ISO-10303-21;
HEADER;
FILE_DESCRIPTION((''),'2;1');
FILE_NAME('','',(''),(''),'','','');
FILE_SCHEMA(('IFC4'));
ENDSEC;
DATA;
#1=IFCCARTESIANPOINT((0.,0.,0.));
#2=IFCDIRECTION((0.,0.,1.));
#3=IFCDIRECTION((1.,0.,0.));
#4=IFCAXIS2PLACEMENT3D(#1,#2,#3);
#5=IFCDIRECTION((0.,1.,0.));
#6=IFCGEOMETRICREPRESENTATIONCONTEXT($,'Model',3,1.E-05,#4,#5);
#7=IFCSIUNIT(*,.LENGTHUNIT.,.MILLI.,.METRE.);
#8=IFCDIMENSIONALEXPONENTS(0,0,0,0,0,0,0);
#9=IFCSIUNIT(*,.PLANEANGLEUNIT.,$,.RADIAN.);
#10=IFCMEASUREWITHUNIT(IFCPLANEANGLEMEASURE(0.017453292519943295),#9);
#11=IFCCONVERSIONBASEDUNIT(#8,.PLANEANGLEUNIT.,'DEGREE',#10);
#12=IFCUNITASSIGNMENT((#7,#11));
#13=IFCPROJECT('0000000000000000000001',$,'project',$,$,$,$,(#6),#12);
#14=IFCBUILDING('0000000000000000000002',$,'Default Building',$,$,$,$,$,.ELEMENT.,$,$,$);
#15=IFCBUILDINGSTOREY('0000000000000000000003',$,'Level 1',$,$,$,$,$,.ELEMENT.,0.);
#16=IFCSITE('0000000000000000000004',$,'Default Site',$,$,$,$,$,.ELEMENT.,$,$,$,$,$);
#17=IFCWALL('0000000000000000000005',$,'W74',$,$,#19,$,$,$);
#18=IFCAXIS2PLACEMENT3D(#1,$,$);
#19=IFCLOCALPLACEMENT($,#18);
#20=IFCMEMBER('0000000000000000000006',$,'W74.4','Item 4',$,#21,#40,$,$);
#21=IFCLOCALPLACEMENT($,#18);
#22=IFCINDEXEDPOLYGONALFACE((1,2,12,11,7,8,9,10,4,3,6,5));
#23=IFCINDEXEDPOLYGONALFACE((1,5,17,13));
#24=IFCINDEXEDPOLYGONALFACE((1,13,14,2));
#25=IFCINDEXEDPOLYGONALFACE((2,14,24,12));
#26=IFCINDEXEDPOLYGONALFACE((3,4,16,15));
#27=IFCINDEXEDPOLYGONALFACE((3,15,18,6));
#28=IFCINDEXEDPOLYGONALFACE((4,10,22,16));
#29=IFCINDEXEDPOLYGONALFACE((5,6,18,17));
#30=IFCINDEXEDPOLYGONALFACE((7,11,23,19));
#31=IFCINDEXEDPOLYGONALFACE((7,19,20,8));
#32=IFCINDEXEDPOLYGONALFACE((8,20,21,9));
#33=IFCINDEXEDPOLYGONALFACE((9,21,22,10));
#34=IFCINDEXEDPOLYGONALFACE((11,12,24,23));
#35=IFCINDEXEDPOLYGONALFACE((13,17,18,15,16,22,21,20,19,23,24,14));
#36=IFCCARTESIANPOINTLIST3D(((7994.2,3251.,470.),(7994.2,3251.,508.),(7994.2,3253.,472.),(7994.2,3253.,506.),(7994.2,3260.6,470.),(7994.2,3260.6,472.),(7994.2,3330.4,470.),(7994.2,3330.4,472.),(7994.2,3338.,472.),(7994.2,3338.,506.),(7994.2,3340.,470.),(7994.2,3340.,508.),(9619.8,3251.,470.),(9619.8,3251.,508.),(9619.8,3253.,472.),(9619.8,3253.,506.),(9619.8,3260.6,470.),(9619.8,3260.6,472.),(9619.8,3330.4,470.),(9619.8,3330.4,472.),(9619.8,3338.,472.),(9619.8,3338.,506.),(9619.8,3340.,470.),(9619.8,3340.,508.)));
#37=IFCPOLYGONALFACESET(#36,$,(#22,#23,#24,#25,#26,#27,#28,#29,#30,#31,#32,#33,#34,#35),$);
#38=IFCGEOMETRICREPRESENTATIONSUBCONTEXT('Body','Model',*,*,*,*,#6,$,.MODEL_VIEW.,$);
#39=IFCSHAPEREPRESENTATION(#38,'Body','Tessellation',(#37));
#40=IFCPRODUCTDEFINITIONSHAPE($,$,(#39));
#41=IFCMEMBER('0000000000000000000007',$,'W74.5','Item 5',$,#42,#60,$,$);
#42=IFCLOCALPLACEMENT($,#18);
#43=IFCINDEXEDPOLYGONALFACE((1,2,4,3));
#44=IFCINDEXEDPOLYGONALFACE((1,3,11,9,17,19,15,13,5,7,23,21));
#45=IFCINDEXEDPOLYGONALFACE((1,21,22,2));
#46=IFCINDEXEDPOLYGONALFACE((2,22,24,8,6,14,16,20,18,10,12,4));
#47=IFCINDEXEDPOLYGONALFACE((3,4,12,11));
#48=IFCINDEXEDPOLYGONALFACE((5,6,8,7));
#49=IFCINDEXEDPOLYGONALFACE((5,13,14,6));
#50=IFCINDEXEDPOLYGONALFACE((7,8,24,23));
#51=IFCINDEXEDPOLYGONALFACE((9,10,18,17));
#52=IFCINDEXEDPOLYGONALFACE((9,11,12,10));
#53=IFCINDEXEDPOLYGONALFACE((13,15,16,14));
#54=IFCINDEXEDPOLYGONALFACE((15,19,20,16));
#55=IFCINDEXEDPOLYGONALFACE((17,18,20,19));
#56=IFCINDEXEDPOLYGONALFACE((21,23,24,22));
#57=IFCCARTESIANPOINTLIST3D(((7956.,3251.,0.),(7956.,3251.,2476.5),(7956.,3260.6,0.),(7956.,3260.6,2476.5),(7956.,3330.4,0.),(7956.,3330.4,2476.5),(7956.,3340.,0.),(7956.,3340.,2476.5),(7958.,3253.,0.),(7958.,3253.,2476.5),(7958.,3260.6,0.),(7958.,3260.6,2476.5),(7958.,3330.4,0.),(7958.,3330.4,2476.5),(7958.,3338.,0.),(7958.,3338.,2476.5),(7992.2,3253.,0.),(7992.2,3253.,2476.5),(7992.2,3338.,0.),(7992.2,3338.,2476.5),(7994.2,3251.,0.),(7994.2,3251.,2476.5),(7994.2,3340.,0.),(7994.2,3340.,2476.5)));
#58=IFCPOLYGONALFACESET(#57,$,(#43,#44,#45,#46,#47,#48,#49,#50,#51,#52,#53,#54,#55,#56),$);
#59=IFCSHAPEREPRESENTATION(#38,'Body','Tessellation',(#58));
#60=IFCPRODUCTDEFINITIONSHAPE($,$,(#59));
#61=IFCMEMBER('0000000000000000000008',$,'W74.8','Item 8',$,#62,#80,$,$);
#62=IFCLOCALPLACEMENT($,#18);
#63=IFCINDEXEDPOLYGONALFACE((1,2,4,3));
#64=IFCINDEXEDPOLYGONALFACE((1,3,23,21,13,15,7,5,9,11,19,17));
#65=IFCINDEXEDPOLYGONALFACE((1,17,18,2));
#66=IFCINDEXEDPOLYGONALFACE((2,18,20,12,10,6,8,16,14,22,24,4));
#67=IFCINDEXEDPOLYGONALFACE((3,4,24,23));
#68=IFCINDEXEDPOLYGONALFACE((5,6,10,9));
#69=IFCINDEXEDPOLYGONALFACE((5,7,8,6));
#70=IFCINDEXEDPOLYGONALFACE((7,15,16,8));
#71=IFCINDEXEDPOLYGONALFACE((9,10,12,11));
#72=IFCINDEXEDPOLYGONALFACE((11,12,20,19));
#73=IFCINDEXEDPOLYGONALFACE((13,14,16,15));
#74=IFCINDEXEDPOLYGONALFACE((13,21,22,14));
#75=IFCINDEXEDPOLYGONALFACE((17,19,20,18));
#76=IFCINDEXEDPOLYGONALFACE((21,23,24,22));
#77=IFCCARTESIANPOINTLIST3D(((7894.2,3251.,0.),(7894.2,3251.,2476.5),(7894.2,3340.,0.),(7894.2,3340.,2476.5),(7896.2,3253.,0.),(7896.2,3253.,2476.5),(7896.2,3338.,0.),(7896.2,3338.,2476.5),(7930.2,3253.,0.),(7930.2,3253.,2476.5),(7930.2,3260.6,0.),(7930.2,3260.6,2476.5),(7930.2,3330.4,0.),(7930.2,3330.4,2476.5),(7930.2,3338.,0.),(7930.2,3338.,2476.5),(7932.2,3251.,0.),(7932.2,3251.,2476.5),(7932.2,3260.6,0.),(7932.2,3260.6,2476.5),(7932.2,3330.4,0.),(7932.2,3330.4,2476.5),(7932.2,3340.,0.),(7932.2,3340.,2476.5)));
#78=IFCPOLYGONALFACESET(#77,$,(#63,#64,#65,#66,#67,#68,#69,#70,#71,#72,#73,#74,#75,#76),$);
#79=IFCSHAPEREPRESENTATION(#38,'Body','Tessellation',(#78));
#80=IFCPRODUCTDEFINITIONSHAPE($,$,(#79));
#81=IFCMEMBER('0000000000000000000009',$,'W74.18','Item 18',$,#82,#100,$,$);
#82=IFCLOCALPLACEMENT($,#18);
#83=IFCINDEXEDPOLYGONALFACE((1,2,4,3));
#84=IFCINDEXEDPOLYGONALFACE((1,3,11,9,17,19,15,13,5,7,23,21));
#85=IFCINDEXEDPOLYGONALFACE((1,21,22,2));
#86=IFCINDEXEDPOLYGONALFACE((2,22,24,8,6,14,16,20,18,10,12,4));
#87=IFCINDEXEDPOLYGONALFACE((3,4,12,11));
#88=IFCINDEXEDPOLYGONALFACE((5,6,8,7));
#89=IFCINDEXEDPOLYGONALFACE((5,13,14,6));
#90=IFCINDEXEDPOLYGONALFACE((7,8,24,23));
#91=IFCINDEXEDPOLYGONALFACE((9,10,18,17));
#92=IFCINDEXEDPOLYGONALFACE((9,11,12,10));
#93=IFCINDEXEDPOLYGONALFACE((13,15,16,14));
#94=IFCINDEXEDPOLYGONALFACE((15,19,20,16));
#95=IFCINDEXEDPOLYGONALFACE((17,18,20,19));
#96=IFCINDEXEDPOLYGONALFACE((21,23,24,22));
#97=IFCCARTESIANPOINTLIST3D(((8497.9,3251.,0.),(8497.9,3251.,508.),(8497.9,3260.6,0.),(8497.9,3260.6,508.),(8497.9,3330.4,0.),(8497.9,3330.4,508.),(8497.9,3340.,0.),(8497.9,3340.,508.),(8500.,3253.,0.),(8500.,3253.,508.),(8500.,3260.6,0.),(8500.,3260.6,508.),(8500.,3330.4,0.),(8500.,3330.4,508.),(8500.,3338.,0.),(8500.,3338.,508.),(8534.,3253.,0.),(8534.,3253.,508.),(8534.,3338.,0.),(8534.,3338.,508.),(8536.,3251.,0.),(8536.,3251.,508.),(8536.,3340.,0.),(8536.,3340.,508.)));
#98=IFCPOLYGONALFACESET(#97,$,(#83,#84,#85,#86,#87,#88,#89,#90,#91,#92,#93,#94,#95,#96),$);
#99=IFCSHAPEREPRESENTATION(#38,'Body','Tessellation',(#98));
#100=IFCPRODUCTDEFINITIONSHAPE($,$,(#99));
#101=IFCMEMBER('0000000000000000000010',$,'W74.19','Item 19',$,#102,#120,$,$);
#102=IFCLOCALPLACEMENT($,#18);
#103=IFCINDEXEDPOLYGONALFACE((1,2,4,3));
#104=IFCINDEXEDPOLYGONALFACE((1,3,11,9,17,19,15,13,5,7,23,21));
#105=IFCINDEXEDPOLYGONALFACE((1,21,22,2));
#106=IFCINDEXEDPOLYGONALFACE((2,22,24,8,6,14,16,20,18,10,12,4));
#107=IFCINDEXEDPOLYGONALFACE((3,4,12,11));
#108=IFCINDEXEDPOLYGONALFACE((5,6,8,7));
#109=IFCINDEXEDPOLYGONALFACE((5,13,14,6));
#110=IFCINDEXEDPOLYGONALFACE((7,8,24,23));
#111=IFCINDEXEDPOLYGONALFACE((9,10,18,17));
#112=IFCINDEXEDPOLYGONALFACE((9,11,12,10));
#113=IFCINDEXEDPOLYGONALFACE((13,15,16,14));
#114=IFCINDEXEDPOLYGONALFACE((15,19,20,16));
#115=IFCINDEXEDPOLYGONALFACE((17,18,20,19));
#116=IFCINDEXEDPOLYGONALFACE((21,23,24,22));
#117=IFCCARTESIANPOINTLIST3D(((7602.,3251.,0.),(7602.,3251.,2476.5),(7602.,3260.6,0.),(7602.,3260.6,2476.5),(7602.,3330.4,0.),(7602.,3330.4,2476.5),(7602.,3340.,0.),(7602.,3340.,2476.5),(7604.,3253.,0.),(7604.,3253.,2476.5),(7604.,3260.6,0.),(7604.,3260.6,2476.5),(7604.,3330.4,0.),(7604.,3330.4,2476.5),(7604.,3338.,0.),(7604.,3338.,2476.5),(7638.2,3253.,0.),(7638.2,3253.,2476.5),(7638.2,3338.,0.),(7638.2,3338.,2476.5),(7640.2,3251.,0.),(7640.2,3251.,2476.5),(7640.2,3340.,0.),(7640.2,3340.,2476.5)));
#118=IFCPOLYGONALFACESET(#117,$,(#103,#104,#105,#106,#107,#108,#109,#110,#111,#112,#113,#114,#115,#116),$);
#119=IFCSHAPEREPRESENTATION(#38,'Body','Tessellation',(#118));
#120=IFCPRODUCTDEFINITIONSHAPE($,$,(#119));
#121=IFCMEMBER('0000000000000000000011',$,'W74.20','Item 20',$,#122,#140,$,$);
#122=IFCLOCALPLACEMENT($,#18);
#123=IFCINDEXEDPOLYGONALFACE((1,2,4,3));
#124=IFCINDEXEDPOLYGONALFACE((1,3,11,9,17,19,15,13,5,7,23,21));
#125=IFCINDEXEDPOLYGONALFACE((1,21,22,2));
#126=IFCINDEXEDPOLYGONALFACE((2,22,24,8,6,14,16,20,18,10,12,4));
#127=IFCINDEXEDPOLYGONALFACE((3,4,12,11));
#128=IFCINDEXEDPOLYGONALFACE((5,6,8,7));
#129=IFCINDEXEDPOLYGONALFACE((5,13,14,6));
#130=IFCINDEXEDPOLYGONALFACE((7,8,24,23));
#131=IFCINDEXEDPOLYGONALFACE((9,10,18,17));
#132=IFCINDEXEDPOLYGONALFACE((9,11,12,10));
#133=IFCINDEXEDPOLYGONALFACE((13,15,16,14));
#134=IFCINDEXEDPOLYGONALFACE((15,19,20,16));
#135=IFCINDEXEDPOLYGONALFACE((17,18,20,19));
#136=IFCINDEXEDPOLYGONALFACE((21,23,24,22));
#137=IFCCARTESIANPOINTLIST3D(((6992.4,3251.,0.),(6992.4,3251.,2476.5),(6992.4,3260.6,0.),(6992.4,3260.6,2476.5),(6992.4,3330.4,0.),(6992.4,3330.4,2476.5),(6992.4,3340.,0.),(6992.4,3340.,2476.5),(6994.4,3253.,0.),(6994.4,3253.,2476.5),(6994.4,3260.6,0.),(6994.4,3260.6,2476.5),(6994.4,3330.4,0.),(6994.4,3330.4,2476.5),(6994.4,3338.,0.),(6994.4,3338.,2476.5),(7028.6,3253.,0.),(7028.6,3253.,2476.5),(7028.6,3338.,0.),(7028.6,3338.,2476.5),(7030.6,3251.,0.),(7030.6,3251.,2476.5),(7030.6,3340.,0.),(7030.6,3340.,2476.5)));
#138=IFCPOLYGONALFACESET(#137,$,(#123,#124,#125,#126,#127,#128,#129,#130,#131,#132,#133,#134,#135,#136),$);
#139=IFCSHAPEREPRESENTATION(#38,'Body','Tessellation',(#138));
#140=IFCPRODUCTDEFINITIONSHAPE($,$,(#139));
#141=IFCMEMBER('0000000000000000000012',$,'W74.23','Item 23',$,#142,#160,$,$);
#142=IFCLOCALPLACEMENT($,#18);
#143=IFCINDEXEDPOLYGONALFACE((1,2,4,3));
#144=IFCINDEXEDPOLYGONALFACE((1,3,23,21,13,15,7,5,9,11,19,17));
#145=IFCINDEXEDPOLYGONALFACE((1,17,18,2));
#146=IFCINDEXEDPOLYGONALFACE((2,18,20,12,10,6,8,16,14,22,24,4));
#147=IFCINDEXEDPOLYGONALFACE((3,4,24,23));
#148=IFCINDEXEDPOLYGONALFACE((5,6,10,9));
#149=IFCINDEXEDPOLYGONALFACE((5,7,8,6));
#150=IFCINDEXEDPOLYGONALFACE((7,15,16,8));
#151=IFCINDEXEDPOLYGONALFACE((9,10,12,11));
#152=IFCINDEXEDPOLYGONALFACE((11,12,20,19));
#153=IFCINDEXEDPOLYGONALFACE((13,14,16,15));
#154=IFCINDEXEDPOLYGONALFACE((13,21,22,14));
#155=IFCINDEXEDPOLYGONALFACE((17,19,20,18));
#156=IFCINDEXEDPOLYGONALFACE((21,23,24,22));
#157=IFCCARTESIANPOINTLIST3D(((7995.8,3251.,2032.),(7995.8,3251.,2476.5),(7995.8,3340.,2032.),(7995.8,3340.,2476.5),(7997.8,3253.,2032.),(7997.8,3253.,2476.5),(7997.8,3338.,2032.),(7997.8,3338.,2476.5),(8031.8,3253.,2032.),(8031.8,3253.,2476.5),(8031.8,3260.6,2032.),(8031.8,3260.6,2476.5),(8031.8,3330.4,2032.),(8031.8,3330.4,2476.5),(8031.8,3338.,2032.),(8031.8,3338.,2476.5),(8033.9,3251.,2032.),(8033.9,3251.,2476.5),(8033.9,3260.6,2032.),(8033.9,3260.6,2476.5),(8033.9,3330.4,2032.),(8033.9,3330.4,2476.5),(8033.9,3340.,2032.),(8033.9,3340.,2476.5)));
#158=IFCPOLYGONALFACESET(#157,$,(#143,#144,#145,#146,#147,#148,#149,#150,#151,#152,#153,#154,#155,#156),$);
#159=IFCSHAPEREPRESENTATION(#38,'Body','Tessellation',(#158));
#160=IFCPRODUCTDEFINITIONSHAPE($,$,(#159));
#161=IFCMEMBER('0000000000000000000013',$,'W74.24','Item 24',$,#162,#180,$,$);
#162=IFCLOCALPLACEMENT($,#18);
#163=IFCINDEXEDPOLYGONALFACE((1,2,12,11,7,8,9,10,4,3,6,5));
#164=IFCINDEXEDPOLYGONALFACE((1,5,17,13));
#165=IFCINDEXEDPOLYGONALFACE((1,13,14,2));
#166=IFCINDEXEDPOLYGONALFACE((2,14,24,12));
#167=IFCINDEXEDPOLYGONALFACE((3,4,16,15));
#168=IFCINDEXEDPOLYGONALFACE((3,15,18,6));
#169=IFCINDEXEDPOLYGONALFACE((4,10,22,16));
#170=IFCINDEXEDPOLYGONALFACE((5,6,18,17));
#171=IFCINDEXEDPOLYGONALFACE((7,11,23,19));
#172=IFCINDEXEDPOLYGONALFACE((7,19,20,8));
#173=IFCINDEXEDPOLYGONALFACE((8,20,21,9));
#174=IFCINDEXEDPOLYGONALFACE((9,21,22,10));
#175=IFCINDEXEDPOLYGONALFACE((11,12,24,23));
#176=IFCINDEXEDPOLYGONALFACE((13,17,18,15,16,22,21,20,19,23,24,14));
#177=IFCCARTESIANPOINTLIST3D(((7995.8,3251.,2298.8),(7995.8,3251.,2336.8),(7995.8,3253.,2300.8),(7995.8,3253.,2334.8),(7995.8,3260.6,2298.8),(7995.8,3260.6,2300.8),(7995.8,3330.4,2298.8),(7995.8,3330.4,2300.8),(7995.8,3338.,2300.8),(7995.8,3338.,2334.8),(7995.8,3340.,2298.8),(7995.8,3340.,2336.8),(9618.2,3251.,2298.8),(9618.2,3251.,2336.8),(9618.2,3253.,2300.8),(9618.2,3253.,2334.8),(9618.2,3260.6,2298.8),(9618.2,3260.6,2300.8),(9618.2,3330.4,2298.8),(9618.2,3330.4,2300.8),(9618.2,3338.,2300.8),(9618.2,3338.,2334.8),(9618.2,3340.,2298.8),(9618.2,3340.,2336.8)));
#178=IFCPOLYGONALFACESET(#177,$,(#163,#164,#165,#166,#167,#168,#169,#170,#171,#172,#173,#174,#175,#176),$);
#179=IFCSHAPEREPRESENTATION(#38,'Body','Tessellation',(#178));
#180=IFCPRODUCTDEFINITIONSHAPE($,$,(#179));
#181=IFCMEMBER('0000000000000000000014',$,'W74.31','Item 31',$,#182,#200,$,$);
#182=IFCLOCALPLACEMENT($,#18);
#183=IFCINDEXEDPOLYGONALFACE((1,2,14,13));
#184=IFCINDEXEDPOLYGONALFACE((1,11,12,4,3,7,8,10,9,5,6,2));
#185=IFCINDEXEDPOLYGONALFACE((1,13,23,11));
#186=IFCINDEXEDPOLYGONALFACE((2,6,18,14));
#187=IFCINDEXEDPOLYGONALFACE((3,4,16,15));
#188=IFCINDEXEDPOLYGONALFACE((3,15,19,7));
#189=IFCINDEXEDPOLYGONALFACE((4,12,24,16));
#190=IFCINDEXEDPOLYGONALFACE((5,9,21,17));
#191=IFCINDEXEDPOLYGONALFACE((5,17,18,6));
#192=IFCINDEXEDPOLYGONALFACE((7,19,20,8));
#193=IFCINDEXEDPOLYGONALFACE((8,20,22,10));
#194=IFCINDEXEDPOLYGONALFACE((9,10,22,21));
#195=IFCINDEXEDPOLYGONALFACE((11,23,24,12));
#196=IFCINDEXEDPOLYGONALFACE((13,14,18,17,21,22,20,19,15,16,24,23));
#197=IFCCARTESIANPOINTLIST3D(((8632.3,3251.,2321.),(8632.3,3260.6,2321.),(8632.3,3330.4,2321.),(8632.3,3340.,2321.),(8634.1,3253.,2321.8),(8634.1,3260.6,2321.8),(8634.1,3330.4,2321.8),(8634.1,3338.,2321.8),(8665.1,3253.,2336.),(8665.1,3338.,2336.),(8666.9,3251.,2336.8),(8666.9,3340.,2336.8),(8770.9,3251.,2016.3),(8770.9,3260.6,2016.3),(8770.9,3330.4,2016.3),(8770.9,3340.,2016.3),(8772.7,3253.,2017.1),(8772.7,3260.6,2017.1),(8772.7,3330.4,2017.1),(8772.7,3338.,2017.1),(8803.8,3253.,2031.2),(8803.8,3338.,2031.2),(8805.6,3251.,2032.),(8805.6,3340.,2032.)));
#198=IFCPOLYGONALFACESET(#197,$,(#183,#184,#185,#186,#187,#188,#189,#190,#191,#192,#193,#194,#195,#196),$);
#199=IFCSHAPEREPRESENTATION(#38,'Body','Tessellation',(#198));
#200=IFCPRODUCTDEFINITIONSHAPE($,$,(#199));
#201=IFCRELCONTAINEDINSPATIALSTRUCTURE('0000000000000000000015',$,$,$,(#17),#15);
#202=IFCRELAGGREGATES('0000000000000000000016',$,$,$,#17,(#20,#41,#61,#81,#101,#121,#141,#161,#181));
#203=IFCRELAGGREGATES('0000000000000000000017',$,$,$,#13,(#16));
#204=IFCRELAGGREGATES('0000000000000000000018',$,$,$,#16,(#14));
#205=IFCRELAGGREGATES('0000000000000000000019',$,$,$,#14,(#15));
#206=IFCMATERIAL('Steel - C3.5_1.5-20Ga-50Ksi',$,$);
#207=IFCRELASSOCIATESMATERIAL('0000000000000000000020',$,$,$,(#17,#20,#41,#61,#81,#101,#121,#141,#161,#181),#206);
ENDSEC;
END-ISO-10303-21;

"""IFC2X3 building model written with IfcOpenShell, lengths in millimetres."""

from ifc_helpers import new_model, entity, si_unit, converted_unit, direction, frame, origin, origin_with_axes, origin_2d_with_axis, place, context, subcontext, project, spatial, c_section, extrude, material, element, aggregate, save


model = new_model("IFC2X3")

# Units and contexts
model_context = context("Model", 3, precision=1e-05, world=origin_with_axes(), true_north=direction((0.0, 1.0, 0.0)))
body_context = subcontext(model_context, "Body", "Model", "MODEL_VIEW")
ifc_project = project(units=[si_unit("LENGTHUNIT", "METRE", prefix="MILLI"), converted_unit("PLANEANGLEUNIT", "DEGREE", entity("IfcPlaneAngleMeasure", 0.017453292519943295), si_unit("PLANEANGLEUNIT", "RADIAN"), dimensions=[0, 0, 0, 0, 0, 0, 0])], contexts=[model_context])

# Site, building, storey
site = spatial("IfcSite", under=ifc_project, Name="Default Site", CompositionType="ELEMENT")
building = spatial("IfcBuilding", under=site, Name="Default Building", CompositionType="ELEMENT")
storey = spatial("IfcBuildingStorey", under=building, Name="Level 1", CompositionType="ELEMENT", Elevation=0.0)

# Wall, members
ifc_material_1 = material(Name="Steel - C3.5_1.5-20Ga-50Ksi")
wall = element("IfcWall", 1, inside=storey, material=ifc_material_1, Name="W74")
member_1_placement = place(None, frame((7994.2, 3295.5, 489.0), z_axis=(1.0, 0.0, 0.0), x_axis=(0.0, 0.0, -1.0)))
member_1 = element("IfcMember", 2, at=member_1_placement, material=ifc_material_1, Name="W74.4", Description="Item 4", context=body_context, shape_type="SweptSolid", body=[
    extrude(c_section(Depth=88.9, Width=38.1, WallThickness=2.0, Girth=9.5, at=origin_2d_with_axis()), origin(), (0.0, 0.0, 1.0), 1625.6),
])
member_2_placement = place(None, frame((7975.1, 3295.5, 2476.5), z_axis=(0.0, 0.0, -1.0), x_axis=(-1.0, 0.0, 0.0)))
member_2 = element("IfcMember", 3, at=member_2_placement, material=ifc_material_1, Name="W74.5", Description="Item 5", context=body_context, shape_type="SweptSolid", body=[
    extrude(c_section(Depth=88.9, Width=38.1, WallThickness=2.0, Girth=9.5, at=origin_2d_with_axis()), origin(), (0.0, 0.0, 1.0), 2476.5),
])
member_3_placement = place(None, frame((7913.2, 3295.5, 0.0), z_axis=(0.0, 0.0, 1.0), x_axis=(1.0, 0.0, 0.0)))
member_3 = element("IfcMember", 4, at=member_3_placement, material=ifc_material_1, Name="W74.8", Description="Item 8", context=body_context, shape_type="SweptSolid", body=[
    extrude(c_section(Depth=88.9, Width=38.1, WallThickness=2.0, Girth=9.5, at=origin_2d_with_axis()), origin(), (0.0, 0.0, 1.0), 2476.5),
])
member_4_placement = place(None, frame((8517.0, 3295.5, 508.0), z_axis=(0.0, 0.0, -1.0), x_axis=(-1.0, 0.0, 0.0)))
member_4 = element("IfcMember", 5, at=member_4_placement, material=ifc_material_1, Name="W74.18", Description="Item 18", context=body_context, shape_type="SweptSolid", body=[
    extrude(c_section(Depth=88.9, Width=38.1, WallThickness=2.0, Girth=9.5, at=origin_2d_with_axis()), origin(), (0.0, 0.0, 1.0), 508.0),
])
member_5_placement = place(None, frame((7621.1, 3295.5, 2476.5), z_axis=(0.0, 0.0, -1.0), x_axis=(-1.0, 0.0, 0.0)))
member_5 = element("IfcMember", 6, at=member_5_placement, material=ifc_material_1, Name="W74.19", Description="Item 19", context=body_context, shape_type="SweptSolid", body=[
    extrude(c_section(Depth=88.9, Width=38.1, WallThickness=2.0, Girth=9.5, at=origin_2d_with_axis()), origin(), (0.0, 0.0, 1.0), 2476.5),
])
member_6_placement = place(None, frame((7011.5, 3295.5, 2476.5), z_axis=(0.0, 0.0, -1.0), x_axis=(-1.0, 0.0, 0.0)))
member_6 = element("IfcMember", 7, at=member_6_placement, material=ifc_material_1, Name="W74.20", Description="Item 20", context=body_context, shape_type="SweptSolid", body=[
    extrude(c_section(Depth=88.9, Width=38.1, WallThickness=2.0, Girth=9.5, at=origin_2d_with_axis()), origin(), (0.0, 0.0, 1.0), 2476.5),
])
member_7_placement = place(None, frame((8014.8, 3295.5, 2032.0), z_axis=(0.0, 0.0, 1.0), x_axis=(1.0, 0.0, 0.0)))
member_7 = element("IfcMember", 8, at=member_7_placement, material=ifc_material_1, Name="W74.23", Description="Item 23", context=body_context, shape_type="SweptSolid", body=[
    extrude(c_section(Depth=88.9, Width=38.1, WallThickness=2.0, Girth=9.5, at=origin_2d_with_axis()), origin(), (0.0, 0.0, 1.0), 444.5),
])
member_8_placement = place(None, frame((7995.8, 3295.5, 2317.8), z_axis=(1.0, 0.0, 0.0), x_axis=(0.0, 0.0, -1.0)))
member_8 = element("IfcMember", 9, at=member_8_placement, material=ifc_material_1, Name="W74.24", Description="Item 24", context=body_context, shape_type="SweptSolid", body=[
    extrude(c_section(Depth=88.9, Width=38.1, WallThickness=2.0, Girth=9.5, at=origin_2d_with_axis()), origin(), (0.0, 0.0, 1.0), 1622.4),
])
member_9_placement = place(None, frame((8649.6, 3295.5, 2328.9), z_axis=(0.414, 0.0, -0.91), x_axis=(-0.91, 0.0, -0.414)))
member_9 = element("IfcMember", 10, at=member_9_placement, material=ifc_material_1, Name="W74.31", Description="Item 31", context=body_context, shape_type="SweptSolid", body=[
    extrude(c_section(Depth=88.9, Width=38.1, WallThickness=2.0, Girth=9.5, at=origin_2d_with_axis()), origin(), (0.0, 0.0, 1.0), 334.8),
])
aggregate(wall, [member_1, member_2, member_3, member_4, member_5, member_6, member_7, member_8, member_9])

save(model, "model.ifc")
